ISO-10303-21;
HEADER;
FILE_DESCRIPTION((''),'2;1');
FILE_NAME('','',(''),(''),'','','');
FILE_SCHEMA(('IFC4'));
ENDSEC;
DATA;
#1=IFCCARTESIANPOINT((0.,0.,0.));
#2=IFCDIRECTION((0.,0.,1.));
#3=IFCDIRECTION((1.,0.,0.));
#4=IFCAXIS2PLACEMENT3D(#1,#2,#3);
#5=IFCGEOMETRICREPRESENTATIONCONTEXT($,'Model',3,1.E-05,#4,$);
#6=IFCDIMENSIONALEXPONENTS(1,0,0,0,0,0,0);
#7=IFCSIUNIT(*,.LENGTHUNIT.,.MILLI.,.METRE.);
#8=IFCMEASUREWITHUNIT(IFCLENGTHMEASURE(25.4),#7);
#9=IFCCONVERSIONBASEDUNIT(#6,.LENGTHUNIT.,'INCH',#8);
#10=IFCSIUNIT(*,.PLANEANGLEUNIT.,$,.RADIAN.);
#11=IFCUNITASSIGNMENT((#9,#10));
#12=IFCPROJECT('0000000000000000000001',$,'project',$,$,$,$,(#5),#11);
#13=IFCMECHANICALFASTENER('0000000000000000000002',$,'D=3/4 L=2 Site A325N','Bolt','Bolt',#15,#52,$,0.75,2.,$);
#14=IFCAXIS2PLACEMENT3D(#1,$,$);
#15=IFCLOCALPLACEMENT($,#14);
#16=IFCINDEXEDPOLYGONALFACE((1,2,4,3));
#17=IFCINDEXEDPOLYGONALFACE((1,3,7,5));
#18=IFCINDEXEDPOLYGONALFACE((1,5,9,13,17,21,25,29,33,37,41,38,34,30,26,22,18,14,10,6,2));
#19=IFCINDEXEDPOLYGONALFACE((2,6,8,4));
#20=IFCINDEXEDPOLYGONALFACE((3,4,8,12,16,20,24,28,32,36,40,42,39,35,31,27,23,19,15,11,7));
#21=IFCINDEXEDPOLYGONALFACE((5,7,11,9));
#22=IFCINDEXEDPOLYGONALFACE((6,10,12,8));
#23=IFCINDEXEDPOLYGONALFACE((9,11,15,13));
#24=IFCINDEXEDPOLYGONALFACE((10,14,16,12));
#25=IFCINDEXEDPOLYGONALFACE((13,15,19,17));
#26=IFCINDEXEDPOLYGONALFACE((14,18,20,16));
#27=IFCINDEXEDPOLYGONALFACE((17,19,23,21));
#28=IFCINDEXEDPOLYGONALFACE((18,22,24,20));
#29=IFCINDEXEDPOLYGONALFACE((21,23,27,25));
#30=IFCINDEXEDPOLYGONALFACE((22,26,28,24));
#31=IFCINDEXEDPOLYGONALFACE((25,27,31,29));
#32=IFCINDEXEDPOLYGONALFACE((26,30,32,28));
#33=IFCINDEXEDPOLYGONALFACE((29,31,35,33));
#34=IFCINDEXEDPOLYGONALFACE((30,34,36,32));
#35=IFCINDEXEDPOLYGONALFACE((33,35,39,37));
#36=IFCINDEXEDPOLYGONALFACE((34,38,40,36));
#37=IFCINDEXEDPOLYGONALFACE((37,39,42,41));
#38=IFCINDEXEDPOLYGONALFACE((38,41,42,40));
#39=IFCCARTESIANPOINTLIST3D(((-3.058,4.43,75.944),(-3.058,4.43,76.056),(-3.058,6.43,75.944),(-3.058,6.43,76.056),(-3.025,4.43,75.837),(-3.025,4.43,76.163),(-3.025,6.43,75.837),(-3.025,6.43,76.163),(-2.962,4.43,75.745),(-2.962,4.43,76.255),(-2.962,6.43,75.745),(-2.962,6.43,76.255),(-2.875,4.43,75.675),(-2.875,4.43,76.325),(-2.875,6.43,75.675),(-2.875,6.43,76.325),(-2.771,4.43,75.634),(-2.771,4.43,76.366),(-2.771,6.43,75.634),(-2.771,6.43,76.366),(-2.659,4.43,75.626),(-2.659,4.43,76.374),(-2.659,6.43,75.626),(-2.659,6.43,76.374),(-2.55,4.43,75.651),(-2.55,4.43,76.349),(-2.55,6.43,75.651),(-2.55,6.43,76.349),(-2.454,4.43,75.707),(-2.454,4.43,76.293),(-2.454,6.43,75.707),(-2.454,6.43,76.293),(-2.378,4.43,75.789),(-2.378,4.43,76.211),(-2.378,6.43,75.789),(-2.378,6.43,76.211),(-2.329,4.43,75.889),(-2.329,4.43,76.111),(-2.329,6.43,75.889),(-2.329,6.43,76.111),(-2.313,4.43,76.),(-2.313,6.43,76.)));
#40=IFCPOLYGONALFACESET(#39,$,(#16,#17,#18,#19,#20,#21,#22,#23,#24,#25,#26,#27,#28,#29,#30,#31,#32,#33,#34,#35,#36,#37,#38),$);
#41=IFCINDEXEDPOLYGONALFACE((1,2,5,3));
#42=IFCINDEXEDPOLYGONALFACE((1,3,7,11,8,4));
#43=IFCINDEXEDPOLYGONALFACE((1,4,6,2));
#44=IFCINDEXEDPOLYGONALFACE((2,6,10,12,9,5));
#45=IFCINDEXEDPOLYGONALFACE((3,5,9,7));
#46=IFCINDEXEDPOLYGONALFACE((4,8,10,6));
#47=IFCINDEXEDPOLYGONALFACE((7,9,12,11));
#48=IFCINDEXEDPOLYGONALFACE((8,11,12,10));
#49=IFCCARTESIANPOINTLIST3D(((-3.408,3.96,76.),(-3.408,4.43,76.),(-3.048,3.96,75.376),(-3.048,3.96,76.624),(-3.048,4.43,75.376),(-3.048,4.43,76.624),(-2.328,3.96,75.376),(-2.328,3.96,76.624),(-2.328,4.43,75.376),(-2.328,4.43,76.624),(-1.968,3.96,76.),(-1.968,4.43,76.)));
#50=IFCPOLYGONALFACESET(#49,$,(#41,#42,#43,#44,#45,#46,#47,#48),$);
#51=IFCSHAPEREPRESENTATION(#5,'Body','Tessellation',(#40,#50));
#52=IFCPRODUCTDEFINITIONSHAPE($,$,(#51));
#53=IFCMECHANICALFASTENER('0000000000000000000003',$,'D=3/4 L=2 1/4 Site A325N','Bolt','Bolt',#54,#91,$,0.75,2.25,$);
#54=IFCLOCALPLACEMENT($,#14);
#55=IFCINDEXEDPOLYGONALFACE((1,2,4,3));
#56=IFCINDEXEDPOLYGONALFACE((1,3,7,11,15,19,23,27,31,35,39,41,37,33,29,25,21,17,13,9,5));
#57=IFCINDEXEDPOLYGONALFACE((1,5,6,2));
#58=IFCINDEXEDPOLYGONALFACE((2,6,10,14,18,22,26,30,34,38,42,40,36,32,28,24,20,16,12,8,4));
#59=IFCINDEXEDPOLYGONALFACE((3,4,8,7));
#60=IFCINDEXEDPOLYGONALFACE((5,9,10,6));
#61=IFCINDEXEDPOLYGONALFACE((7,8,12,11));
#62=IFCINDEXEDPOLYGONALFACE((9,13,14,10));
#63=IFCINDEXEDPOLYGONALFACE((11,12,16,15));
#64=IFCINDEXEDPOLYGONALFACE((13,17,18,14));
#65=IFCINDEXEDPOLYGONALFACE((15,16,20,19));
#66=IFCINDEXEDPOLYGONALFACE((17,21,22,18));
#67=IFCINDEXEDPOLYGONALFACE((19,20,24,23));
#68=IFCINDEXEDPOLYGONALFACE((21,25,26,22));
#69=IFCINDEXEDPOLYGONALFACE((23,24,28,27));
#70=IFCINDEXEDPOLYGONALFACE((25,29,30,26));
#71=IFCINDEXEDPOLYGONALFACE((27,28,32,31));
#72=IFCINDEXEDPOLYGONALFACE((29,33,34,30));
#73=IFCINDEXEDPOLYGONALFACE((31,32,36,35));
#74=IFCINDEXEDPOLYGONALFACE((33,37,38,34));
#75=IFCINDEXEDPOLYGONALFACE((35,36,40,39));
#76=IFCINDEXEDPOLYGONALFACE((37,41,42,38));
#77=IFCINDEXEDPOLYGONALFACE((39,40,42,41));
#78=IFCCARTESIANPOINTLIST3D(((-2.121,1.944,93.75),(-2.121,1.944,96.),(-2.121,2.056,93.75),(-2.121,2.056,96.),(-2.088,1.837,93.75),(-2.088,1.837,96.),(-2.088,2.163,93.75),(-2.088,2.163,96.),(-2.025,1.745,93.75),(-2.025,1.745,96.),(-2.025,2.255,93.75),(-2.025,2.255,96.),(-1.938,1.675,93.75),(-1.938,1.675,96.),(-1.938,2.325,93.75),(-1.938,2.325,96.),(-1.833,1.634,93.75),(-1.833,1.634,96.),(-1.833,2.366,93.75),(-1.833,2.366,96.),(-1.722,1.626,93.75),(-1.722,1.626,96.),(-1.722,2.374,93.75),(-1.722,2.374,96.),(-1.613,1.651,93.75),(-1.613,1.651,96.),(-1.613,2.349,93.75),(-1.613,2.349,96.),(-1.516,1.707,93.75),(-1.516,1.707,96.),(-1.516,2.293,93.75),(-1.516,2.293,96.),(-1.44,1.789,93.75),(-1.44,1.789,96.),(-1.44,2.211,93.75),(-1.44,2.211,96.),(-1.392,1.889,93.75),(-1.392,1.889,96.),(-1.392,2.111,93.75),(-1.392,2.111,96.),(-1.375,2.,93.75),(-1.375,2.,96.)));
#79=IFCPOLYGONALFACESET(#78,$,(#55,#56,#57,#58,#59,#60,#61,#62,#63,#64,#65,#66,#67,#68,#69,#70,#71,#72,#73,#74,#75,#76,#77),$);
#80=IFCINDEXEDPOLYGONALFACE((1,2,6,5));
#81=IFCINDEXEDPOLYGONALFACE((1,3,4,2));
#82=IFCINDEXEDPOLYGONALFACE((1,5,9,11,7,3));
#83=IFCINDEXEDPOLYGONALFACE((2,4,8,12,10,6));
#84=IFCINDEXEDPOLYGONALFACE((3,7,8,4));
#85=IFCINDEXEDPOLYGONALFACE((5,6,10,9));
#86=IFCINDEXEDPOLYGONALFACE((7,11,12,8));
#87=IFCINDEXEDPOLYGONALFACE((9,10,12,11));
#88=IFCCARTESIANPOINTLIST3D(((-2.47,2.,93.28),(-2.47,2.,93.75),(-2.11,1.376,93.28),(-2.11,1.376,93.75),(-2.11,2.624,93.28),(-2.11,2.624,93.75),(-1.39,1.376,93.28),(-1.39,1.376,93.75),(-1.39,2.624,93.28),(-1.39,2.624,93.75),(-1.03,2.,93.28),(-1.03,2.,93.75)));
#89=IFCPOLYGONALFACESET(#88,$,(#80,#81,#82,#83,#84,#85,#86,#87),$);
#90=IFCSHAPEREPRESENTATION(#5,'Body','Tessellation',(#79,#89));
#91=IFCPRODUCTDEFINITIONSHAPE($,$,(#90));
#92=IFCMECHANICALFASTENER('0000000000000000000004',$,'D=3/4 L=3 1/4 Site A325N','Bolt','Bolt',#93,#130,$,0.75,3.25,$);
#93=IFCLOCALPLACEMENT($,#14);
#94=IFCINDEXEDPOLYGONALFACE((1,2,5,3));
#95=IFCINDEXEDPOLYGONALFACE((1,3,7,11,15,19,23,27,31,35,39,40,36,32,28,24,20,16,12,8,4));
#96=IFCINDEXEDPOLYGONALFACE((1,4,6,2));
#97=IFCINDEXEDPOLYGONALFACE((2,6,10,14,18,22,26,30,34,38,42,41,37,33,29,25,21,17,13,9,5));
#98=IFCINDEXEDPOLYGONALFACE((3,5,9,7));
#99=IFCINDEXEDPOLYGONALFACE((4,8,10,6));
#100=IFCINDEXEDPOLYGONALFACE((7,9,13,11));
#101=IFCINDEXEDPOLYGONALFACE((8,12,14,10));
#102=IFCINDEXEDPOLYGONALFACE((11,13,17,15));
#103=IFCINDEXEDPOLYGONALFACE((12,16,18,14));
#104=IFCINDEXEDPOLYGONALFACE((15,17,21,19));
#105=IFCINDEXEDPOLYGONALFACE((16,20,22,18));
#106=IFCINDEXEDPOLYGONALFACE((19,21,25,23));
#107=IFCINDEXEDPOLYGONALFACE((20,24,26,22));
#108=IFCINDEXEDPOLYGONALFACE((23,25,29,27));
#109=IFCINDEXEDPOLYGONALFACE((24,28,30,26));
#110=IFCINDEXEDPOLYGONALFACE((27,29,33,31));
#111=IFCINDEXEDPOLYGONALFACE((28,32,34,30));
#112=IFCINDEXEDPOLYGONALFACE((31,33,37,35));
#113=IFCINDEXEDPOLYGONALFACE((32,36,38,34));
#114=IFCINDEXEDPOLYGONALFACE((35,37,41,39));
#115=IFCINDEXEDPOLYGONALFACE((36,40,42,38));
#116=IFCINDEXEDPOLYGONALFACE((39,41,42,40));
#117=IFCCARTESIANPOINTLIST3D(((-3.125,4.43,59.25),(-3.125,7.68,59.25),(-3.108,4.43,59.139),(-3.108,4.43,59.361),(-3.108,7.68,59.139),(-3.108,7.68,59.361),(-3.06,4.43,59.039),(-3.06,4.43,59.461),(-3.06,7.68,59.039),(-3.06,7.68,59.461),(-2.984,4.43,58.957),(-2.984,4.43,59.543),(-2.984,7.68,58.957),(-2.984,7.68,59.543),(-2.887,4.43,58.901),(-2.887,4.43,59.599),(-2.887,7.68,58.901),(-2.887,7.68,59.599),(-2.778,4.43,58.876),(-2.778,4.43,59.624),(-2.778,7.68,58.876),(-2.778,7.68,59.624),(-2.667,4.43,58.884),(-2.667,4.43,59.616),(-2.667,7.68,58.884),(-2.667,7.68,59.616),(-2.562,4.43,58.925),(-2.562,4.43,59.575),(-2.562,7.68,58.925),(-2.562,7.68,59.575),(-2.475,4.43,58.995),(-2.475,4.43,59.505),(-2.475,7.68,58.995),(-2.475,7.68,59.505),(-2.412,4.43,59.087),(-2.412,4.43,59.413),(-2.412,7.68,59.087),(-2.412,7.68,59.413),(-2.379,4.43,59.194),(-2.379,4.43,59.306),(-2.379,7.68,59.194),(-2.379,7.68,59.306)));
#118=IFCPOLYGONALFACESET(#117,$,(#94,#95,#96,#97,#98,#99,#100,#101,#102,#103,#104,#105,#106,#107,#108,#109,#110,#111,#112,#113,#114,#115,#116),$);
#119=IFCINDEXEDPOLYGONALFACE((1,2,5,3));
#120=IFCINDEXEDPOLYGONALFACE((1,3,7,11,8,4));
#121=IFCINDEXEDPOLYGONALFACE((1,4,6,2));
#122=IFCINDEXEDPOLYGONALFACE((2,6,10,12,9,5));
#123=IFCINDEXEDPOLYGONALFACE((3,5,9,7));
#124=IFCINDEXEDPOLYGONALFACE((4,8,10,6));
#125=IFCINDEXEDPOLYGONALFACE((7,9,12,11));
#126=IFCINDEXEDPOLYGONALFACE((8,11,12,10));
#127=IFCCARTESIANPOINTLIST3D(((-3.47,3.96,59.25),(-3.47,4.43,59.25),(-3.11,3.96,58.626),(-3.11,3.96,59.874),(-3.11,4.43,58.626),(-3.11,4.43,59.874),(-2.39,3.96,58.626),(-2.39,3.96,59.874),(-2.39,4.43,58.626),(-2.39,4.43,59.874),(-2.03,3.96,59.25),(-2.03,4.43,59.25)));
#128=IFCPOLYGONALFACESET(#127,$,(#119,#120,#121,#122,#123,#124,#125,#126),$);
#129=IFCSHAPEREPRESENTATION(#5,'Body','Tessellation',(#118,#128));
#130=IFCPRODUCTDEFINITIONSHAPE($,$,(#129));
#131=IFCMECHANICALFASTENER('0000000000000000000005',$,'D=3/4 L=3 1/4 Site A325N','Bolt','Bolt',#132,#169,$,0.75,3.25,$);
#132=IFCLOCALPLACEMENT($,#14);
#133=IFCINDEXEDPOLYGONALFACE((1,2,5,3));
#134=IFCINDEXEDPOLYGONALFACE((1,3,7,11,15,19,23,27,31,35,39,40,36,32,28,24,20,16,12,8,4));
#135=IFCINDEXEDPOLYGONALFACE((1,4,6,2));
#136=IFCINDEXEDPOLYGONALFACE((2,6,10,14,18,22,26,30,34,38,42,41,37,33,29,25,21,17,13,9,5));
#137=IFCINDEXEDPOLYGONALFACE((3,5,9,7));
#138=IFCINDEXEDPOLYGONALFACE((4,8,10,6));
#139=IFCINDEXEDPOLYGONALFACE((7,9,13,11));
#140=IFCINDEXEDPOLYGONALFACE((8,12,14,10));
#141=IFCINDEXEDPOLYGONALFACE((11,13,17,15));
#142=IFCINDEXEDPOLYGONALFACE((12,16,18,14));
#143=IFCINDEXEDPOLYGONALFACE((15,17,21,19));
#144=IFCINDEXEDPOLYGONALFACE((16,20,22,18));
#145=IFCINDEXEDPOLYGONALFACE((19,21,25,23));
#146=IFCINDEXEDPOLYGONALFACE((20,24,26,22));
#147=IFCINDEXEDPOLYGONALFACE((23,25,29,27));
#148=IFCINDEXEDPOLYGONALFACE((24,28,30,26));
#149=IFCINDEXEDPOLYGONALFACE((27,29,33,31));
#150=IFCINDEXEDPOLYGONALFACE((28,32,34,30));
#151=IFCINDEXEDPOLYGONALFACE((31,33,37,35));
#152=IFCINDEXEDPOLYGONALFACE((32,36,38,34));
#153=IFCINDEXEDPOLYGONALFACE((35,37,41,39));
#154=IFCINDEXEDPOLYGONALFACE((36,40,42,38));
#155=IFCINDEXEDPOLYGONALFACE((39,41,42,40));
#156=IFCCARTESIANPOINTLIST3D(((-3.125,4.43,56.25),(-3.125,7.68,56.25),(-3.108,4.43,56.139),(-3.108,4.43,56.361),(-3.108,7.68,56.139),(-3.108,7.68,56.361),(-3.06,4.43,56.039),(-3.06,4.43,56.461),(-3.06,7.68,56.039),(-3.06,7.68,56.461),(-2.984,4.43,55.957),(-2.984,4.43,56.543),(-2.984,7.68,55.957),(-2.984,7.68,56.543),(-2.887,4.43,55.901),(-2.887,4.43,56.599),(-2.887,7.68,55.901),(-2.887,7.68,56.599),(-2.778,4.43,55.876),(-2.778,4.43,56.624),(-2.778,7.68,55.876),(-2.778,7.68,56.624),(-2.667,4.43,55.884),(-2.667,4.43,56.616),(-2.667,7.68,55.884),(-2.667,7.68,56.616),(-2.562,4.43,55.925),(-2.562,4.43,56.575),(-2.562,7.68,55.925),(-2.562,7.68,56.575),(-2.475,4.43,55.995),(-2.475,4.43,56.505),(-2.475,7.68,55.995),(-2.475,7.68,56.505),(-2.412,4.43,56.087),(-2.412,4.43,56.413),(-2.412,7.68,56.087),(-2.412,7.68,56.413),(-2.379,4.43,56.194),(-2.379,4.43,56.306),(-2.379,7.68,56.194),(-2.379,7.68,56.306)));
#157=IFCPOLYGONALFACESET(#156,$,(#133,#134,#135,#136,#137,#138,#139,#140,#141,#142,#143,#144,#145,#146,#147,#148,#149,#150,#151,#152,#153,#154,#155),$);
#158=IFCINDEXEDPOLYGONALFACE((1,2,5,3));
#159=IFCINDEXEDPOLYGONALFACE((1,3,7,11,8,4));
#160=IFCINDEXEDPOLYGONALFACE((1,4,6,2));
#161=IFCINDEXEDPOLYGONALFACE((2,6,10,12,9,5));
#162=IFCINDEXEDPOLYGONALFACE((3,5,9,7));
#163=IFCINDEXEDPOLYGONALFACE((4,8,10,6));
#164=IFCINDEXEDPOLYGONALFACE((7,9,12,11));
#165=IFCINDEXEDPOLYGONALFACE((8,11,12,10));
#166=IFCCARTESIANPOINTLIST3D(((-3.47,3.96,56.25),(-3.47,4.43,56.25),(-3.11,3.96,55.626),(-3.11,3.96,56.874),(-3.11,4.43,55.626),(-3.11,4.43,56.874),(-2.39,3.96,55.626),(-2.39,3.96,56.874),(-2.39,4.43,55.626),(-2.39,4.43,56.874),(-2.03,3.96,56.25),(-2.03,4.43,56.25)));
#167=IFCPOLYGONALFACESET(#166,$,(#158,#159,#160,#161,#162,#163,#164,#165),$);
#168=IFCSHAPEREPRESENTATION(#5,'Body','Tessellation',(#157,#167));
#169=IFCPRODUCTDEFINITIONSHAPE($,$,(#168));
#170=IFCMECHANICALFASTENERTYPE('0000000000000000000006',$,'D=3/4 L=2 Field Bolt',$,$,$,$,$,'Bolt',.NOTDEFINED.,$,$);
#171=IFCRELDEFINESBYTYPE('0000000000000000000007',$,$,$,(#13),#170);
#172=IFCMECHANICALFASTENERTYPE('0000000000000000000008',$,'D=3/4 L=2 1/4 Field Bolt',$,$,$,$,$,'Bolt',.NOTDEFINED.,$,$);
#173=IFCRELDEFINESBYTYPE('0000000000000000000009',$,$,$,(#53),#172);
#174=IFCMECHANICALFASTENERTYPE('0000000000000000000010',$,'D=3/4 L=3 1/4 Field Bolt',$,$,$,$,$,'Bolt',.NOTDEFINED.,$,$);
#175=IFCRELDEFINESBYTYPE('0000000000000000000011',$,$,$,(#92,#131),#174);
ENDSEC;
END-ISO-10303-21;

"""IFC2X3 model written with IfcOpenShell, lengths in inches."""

from ifc_helpers import new_model, entity, si_unit, converted_unit, frame, origin_with_axes, origin_2d_with_axis, place, context, project, polyline, circle, outline, extrude, source, transform, mapped, type_object, type_shapes, element, save


model = new_model("IFC2X3")

# Units and contexts
model_context = context("Model", 3, precision=1e-05, world=origin_with_axes())
ifc_project = project(units=[converted_unit("LENGTHUNIT", "INCH", entity("IfcLengthMeasure", 25.4), si_unit("LENGTHUNIT", "METRE", prefix="MILLI"), dimensions=[1, 0, 0, 0, 0, 0, 0]), si_unit("PLANEANGLEUNIT", "RADIAN")], contexts=[model_context])

# Mechanical fasteners
placement_1 = place(None, origin_with_axes())
placement_2 = place(placement_1, origin_with_axes())
placement_3 = place(placement_2, frame((0.0, 0.0, 80.0), z_axis=(0.0, 0.0, 1.0), x_axis=(0.0, 1.0, 0.0)))
mechanical_fastener_type_1 = type_object("IfcMechanicalFastenerType", Name="D=3/4 L=2 Field Bolt", ElementType="Bolt")
shared_shape_1 = source(origin_with_axes(), model_context, "Body", "SweptSolid", [
    extrude(circle(Radius=0.375, at=origin_2d_with_axis()), frame((0.0, 0.0, 0.0), z_axis=(1.0, 0.0, 0.0), x_axis=(0.0, 1.0, 0.0)), (0.0, 0.0, 1.0), 2.0),
    extrude(outline(polyline([(-0.72, 0.0), (-0.36, 0.624), (0.36, 0.624), (0.72, 0.0), (0.36, -0.624), (-0.36, -0.624), (-0.72, 0.0)])), frame((0.0, 0.0, 0.0), z_axis=(1.0, 0.0, 0.0), x_axis=(0.0, 1.0, 0.0)), (0.0, 0.0, -1.0), 0.47),
])
type_shapes(mechanical_fastener_type_1, [shared_shape_1])
placement_4 = place(placement_3, frame((4.43, 2.688, -4.0), z_axis=(0.0, 0.0, -1.0), x_axis=(1.0, 0.0, 0.0)))
for number, where, z_axis, x_axis, name in (
    (1, (0.0, 0.0, 0.0), (0.0, 0.0, 1.0), (1.0, 0.0, 0.0), "D=3/4 L=2 Site A325N"),
):
    element("IfcMechanicalFastener", number, at=place(placement_4, frame(where, z_axis=z_axis, x_axis=x_axis)), type_object=mechanical_fastener_type_1, Name=name, Description="Bolt", ObjectType="Bolt", NominalDiameter=0.75, NominalLength=2.0, context=model_context, shape_type="MappedRepresentation", body=[
        mapped(shared_shape_1, transform((0.0, 0.0, 0.0), scale=1.0)),
    ])
mechanical_fastener_type_2 = type_object("IfcMechanicalFastenerType", Name="D=3/4 L=2 1/4 Field Bolt", ElementType="Bolt")
shared_shape_2 = source(origin_with_axes(), model_context, "Body", "SweptSolid", [
    extrude(circle(Radius=0.375, at=origin_2d_with_axis()), frame((0.0, 0.0, 0.0), z_axis=(1.0, 0.0, 0.0), x_axis=(0.0, 1.0, 0.0)), (0.0, 0.0, 1.0), 2.25),
    extrude(outline(polyline([(-0.72, 0.0), (-0.36, 0.624), (0.36, 0.624), (0.72, 0.0), (0.36, -0.624), (-0.36, -0.624), (-0.72, 0.0)])), frame((0.0, 0.0, 0.0), z_axis=(1.0, 0.0, 0.0), x_axis=(0.0, 1.0, 0.0)), (0.0, 0.0, -1.0), 0.47),
])
type_shapes(mechanical_fastener_type_2, [shared_shape_2])
placement_5 = place(placement_2, frame((0.0, 0.0, 54.5), z_axis=(0.0, -1.0, 0.0), x_axis=(0.0, 0.0, 1.0)))
placement_6 = place(placement_5, frame((39.25, -1.75, -2.0), z_axis=(0.0, 0.0, -1.0), x_axis=(1.0, 0.0, 0.0)))
mechanical_fastener_1_placement = place(placement_6, frame((0.0, -3.5, 0.0), z_axis=(0.0, 0.0, 1.0), x_axis=(1.0, 0.0, 0.0)))
element("IfcMechanicalFastener", 2, at=mechanical_fastener_1_placement, type_object=mechanical_fastener_type_2, Name="D=3/4 L=2 1/4 Site A325N", Description="Bolt", ObjectType="Bolt", NominalDiameter=0.75, NominalLength=2.25, context=model_context, shape_type="MappedRepresentation", body=[
    mapped(shared_shape_2, transform((0.0, 0.0, 0.0), scale=1.0)),
])
mechanical_fastener_type_3 = type_object("IfcMechanicalFastenerType", Name="D=3/4 L=3 1/4 Field Bolt", ElementType="Bolt")
shared_shape_3 = source(origin_with_axes(), model_context, "Body", "SweptSolid", [
    extrude(circle(Radius=0.375, at=origin_2d_with_axis()), frame((0.0, 0.0, 0.0), z_axis=(1.0, 0.0, 0.0), x_axis=(0.0, 1.0, 0.0)), (0.0, 0.0, 1.0), 3.25),
    extrude(outline(polyline([(-0.72, 0.0), (-0.36, 0.624), (0.36, 0.624), (0.72, 0.0), (0.36, -0.624), (-0.36, -0.624), (-0.72, 0.0)])), frame((0.0, 0.0, 0.0), z_axis=(1.0, 0.0, 0.0), x_axis=(0.0, 1.0, 0.0)), (0.0, 0.0, -1.0), 0.47),
])
type_shapes(mechanical_fastener_type_3, [shared_shape_3])
placement_7 = place(placement_5, frame((1.75, 2.75, -4.43), z_axis=(1.0, 0.0, 0.0), x_axis=(0.0, 0.0, -1.0)))
for number, where, z_axis, x_axis, name in (
    (3, (0.0, 0.0, 3.0), (0.0, 0.0, 1.0), (1.0, 0.0, 0.0), "D=3/4 L=3 1/4 Site A325N"),
    (4, (0.0, 0.0, 0.0), (0.0, 0.0, 1.0), (1.0, 0.0, 0.0), "D=3/4 L=3 1/4 Site A325N"),
):
    element("IfcMechanicalFastener", number, at=place(placement_7, frame(where, z_axis=z_axis, x_axis=x_axis)), type_object=mechanical_fastener_type_3, Name=name, Description="Bolt", ObjectType="Bolt", NominalDiameter=0.75, NominalLength=3.25, context=model_context, shape_type="MappedRepresentation", body=[
        mapped(shared_shape_3, transform((0.0, 0.0, 0.0), scale=1.0)),
    ])

save(model, "model.ifc")
